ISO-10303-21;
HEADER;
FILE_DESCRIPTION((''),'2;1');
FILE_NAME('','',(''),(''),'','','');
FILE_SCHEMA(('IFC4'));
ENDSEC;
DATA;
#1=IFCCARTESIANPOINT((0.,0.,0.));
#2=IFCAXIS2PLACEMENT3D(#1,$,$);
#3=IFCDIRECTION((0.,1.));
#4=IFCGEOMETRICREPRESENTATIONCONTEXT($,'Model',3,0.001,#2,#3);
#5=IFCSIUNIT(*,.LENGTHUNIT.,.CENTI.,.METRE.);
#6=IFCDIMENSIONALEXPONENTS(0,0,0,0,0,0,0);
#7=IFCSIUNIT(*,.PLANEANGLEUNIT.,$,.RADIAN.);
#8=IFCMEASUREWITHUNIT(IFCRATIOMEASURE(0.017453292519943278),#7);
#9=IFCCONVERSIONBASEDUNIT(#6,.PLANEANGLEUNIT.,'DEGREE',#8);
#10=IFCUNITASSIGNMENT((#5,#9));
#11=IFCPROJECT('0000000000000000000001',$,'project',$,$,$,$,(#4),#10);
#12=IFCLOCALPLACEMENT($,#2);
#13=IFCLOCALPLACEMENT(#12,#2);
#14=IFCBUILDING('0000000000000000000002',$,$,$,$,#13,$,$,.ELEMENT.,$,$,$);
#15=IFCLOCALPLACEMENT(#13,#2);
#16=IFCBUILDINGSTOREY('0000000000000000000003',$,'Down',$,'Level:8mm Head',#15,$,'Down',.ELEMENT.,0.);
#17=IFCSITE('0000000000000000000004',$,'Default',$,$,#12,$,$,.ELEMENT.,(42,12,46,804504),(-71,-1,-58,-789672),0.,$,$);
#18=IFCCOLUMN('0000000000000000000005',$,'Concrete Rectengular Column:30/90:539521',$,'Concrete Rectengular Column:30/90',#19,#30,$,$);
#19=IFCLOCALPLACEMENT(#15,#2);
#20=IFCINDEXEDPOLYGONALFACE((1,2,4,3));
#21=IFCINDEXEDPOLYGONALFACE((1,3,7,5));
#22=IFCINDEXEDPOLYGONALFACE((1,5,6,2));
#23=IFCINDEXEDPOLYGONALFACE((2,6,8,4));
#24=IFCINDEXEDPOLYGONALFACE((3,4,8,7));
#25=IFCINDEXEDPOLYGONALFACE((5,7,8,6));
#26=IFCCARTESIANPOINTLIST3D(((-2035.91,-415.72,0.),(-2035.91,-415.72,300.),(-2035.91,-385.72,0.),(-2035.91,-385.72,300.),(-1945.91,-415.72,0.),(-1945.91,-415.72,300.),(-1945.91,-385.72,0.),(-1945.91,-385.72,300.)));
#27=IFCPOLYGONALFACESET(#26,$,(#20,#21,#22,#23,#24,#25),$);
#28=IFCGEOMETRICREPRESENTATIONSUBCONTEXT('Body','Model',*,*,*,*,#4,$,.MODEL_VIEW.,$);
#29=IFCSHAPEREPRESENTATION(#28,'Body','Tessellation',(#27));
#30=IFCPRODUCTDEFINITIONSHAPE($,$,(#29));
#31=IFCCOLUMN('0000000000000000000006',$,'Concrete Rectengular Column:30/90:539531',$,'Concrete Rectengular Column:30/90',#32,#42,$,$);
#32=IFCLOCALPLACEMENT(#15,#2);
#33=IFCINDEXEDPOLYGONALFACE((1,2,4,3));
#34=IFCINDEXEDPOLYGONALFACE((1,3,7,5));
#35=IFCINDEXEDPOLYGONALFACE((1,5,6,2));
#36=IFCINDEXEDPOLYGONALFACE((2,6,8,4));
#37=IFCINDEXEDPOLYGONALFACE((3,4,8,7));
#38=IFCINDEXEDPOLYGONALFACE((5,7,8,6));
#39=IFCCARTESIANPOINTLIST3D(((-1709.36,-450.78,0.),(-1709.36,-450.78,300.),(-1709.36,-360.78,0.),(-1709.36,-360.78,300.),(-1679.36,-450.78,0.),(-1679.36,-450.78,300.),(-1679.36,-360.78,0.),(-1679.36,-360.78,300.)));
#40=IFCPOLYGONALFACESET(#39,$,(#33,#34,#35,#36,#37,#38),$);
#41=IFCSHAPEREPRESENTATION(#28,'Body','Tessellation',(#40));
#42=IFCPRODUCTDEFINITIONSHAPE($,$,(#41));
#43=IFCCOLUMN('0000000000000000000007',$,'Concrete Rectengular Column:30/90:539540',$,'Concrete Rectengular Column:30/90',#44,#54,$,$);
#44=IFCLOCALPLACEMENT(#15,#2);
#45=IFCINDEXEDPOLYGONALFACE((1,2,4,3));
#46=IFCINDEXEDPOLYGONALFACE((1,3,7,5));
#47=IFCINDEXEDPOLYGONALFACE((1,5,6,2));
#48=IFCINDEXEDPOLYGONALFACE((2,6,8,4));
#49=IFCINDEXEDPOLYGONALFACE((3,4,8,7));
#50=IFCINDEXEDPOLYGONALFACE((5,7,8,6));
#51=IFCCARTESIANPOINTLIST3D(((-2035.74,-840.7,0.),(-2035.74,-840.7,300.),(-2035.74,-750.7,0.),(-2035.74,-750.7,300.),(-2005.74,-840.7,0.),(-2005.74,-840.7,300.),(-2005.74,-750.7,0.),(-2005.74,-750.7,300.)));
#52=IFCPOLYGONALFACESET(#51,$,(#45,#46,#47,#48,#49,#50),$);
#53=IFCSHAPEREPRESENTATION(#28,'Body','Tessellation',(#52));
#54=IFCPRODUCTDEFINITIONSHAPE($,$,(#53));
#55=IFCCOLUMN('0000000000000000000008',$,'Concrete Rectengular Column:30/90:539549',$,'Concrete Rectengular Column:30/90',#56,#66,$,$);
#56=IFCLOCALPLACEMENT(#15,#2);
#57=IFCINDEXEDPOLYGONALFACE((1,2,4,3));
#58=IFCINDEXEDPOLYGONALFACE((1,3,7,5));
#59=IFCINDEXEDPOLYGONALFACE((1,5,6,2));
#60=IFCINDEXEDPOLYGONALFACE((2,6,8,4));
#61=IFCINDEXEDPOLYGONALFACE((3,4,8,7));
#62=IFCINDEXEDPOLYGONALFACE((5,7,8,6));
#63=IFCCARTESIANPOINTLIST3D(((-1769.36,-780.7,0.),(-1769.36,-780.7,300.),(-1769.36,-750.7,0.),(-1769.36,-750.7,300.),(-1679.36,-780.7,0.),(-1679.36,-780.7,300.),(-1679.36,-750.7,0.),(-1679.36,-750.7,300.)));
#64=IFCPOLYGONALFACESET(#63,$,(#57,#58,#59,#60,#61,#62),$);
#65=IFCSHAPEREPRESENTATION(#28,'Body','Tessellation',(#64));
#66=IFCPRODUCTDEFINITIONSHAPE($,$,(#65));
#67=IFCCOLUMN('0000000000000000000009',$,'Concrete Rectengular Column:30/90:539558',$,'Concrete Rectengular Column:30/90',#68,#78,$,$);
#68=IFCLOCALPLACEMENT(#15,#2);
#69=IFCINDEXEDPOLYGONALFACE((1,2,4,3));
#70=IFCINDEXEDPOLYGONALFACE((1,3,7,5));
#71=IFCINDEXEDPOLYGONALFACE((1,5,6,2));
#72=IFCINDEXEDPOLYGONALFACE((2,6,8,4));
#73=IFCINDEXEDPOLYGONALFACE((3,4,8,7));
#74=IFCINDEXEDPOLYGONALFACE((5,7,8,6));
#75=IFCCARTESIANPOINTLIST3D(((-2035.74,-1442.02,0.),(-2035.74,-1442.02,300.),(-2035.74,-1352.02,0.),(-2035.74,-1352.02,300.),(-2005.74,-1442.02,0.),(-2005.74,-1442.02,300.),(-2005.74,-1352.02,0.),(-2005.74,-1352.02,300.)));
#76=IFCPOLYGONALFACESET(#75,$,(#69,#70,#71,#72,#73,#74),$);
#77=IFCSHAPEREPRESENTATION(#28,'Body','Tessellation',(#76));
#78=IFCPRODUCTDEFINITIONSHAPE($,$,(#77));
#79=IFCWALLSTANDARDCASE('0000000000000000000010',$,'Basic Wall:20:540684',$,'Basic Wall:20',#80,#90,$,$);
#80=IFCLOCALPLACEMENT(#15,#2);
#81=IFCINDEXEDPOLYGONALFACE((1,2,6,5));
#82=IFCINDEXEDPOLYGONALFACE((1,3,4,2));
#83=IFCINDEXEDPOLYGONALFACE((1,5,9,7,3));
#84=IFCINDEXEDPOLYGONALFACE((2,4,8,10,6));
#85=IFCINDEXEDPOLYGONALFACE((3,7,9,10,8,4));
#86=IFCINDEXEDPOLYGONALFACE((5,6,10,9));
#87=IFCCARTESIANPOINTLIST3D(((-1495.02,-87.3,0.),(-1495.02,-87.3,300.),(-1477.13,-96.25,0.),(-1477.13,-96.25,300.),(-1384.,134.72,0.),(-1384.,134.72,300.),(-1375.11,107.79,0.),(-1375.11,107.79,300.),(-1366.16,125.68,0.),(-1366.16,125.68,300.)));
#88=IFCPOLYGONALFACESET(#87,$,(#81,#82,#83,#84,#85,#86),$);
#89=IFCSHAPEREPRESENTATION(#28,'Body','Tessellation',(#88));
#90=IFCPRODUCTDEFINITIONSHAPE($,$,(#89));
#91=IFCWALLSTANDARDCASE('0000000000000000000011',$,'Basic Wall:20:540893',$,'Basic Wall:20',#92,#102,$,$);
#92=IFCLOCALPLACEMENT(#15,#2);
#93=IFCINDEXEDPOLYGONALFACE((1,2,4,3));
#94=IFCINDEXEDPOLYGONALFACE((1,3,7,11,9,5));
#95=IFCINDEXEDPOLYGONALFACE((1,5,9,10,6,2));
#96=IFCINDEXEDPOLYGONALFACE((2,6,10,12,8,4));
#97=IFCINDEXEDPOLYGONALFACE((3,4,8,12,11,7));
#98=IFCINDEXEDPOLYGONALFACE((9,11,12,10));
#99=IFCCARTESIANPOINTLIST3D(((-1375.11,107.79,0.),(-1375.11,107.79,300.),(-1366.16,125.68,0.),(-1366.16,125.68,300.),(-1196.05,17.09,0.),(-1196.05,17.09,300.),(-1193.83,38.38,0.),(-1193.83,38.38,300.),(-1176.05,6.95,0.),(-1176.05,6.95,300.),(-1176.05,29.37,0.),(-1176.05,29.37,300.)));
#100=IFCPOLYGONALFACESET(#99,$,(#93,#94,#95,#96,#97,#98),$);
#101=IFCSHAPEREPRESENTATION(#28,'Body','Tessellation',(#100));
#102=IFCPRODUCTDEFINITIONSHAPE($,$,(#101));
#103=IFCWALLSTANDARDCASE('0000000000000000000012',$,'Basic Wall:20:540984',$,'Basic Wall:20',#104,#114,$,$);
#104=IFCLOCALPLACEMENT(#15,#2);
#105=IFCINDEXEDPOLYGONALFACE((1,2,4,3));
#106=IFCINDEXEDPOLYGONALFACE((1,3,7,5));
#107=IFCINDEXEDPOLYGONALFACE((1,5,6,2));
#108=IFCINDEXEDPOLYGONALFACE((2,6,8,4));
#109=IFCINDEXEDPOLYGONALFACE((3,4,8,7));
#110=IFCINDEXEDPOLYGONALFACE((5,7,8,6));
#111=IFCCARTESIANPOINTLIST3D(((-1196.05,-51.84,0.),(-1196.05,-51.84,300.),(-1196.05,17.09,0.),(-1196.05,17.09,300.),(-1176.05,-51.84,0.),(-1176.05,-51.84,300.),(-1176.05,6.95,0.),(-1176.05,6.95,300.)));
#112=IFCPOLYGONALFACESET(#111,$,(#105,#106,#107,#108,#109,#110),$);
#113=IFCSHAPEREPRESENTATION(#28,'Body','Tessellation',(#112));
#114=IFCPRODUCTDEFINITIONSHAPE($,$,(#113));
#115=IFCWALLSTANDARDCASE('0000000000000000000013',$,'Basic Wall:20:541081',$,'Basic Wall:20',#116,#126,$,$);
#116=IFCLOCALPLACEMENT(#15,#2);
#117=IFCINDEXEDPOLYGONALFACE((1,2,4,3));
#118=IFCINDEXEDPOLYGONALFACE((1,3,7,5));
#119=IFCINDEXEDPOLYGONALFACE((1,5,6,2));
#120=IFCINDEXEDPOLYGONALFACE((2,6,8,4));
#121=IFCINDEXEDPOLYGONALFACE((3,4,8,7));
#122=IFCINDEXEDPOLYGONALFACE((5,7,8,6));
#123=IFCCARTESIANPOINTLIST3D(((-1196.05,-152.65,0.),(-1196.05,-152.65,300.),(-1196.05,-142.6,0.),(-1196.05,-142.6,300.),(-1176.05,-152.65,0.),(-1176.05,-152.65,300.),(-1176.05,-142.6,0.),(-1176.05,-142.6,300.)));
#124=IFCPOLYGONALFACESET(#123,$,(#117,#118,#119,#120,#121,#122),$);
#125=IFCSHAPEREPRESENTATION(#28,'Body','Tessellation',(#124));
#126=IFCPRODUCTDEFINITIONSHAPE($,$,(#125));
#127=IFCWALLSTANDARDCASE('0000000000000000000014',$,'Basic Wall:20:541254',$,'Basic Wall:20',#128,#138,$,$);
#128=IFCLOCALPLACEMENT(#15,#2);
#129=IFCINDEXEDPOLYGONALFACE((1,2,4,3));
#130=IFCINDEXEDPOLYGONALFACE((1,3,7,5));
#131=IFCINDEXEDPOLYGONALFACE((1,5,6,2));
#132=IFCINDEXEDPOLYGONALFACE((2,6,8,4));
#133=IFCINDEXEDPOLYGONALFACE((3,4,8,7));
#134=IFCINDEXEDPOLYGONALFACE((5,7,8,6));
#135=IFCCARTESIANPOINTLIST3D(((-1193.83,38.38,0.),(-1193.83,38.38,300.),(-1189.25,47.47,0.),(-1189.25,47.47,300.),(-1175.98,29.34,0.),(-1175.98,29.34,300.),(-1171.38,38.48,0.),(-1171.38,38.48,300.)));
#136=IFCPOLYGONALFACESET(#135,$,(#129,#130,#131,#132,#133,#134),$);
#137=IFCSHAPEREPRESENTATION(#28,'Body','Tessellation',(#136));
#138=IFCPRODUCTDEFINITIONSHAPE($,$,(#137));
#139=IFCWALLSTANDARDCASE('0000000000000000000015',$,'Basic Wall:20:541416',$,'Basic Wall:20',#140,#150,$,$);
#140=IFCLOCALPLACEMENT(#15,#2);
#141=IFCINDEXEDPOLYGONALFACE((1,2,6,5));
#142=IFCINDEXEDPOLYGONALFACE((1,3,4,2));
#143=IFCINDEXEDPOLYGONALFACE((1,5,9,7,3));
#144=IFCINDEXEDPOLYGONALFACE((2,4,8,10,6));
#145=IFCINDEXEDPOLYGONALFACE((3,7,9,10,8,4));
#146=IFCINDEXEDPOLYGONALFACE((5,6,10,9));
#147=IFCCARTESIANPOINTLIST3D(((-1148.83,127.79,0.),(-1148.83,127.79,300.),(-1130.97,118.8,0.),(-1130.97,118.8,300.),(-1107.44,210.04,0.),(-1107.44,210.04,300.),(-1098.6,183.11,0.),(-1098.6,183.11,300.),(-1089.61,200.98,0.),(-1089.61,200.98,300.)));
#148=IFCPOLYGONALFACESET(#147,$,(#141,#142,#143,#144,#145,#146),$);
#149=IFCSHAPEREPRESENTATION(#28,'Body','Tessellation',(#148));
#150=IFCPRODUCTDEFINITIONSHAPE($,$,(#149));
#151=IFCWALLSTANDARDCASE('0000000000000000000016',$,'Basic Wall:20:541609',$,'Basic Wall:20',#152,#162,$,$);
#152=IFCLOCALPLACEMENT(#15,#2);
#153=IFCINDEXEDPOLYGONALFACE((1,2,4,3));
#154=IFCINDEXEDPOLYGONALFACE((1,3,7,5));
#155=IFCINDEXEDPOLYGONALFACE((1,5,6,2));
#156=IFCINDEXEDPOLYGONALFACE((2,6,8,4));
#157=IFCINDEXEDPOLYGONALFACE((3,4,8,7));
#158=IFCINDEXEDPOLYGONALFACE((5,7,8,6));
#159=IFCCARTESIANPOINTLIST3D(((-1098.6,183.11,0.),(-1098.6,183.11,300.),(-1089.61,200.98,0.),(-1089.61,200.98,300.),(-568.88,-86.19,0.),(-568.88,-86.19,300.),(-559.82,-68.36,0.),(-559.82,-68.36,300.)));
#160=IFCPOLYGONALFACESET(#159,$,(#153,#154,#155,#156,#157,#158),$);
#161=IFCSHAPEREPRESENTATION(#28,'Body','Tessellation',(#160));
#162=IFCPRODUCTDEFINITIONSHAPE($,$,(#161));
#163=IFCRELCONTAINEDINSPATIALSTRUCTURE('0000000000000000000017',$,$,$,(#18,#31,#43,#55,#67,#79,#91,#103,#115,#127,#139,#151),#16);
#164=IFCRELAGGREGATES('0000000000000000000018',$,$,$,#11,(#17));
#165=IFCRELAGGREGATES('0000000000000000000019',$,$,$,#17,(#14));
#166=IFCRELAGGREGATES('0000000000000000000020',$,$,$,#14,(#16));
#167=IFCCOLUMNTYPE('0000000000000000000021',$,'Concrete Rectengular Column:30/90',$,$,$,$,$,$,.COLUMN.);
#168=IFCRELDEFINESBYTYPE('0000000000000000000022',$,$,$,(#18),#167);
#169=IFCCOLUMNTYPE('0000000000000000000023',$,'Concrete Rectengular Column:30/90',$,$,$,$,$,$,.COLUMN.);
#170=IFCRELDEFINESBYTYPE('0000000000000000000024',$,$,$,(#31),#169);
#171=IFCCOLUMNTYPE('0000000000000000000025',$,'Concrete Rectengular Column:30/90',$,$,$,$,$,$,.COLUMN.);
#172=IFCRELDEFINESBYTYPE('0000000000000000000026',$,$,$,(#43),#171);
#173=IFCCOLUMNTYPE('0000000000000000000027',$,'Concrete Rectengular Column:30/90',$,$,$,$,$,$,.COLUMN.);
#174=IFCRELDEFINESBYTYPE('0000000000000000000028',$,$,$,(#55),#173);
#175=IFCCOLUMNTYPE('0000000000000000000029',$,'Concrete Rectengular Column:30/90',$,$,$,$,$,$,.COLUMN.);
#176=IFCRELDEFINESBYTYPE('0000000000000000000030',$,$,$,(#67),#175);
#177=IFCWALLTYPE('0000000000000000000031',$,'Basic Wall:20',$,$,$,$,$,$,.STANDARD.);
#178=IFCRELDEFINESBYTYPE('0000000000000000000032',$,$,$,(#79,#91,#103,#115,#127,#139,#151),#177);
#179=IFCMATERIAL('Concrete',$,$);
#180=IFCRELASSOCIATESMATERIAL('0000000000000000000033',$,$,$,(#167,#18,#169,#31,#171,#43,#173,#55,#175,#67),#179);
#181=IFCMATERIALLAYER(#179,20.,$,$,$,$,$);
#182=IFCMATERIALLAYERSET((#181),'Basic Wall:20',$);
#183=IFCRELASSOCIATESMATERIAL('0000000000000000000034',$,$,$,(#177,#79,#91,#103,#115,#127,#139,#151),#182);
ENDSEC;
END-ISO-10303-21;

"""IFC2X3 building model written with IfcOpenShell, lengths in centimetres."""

from ifc_helpers import new_model, entity, si_unit, converted_unit, direction, frame, frame_2d, origin, origin_2d_with_axis, place, context, subcontext, project, spatial, polyline, rectangle, outline, extrude, source, transform, mapped, material, layer, layer_set, layer_usage, type_object, type_shapes, element, save


model = new_model("IFC2X3")

# Units and contexts
model_context = context("Model", 3, precision=0.001, world=origin(), true_north=direction((0.0, 1.0)))
body_context = subcontext(model_context, "Body", "Model", "MODEL_VIEW")
ifc_project = project(units=[si_unit("LENGTHUNIT", "METRE", prefix="CENTI"), converted_unit("PLANEANGLEUNIT", "DEGREE", entity("IfcRatioMeasure", 0.017453292519943278), si_unit("PLANEANGLEUNIT", "RADIAN"), dimensions=[0, 0, 0, 0, 0, 0, 0])], contexts=[model_context])

# Site, building, storey
site_placement = place(None, origin())
site = spatial("IfcSite", under=ifc_project, at=site_placement, Name="Default", CompositionType="ELEMENT", RefLatitude=(42, 12, 46, 804504), RefLongitude=(-71, -1, -58, -789672), RefElevation=0.0)
building_placement = place(site_placement, origin())
building = spatial("IfcBuilding", under=site, at=building_placement, CompositionType="ELEMENT")
storey_placement = place(building_placement, origin())
storey = spatial("IfcBuildingStorey", under=building, at=storey_placement, Name="Down", ObjectType="Level:8mm Head", LongName="Down", CompositionType="ELEMENT", Elevation=0.0)

# Columns
ifc_material = material(Name="Concrete")
column_type_1 = type_object("IfcColumnType", Name="Concrete Rectengular Column:30/90", PredefinedType="COLUMN", material=ifc_material)
shared_shape_1 = source(origin(), body_context, "Body", "SweptSolid", [
    extrude(rectangle(XDim=30.0, YDim=90.0, at=frame_2d((0.0, 0.0), x_axis=(1.0, 0.0))), frame((-1990.91, -400.72, 0.0), z_axis=(0.0, 0.0, 1.0), x_axis=(0.0, -1.0, 0.0)), (0.0, 0.0, 1.0), 300.0),
])
type_shapes(column_type_1, [shared_shape_1])
column_1_placement = place(storey_placement, origin())
element("IfcColumn", 1, at=column_1_placement, inside=storey, type_object=column_type_1, material=ifc_material, Name="Concrete Rectengular Column:30/90:539521", ObjectType="Concrete Rectengular Column:30/90", context=body_context, shape_type="MappedRepresentation", body=[
    mapped(shared_shape_1, transform((0.0, 0.0, 0.0), scale=1.0)),
])
column_type_2 = type_object("IfcColumnType", Name="Concrete Rectengular Column:30/90", PredefinedType="COLUMN", material=ifc_material)
shared_shape_2 = source(origin(), body_context, "Body", "SweptSolid", [
    extrude(rectangle(XDim=90.0, YDim=30.0, at=origin_2d_with_axis()), frame((-1694.36, -405.78, 0.0), z_axis=(0.0, 0.0, 1.0), x_axis=(0.0, -1.0, 0.0)), (0.0, 0.0, 1.0), 300.0),
])
type_shapes(column_type_2, [shared_shape_2])
column_2_placement = place(storey_placement, origin())
element("IfcColumn", 2, at=column_2_placement, inside=storey, type_object=column_type_2, material=ifc_material, Name="Concrete Rectengular Column:30/90:539531", ObjectType="Concrete Rectengular Column:30/90", context=body_context, shape_type="MappedRepresentation", body=[
    mapped(shared_shape_2, transform((0.0, 0.0, 0.0), scale=1.0)),
])
column_type_3 = type_object("IfcColumnType", Name="Concrete Rectengular Column:30/90", PredefinedType="COLUMN", material=ifc_material)
shared_shape_3 = source(origin(), body_context, "Body", "SweptSolid", [
    extrude(rectangle(XDim=90.0, YDim=30.0, at=origin_2d_with_axis()), frame((-2020.74, -795.7, 0.0), z_axis=(0.0, 0.0, 1.0), x_axis=(0.0, -1.0, 0.0)), (0.0, 0.0, 1.0), 300.0),
])
type_shapes(column_type_3, [shared_shape_3])
column_3_placement = place(storey_placement, origin())
element("IfcColumn", 3, at=column_3_placement, inside=storey, type_object=column_type_3, material=ifc_material, Name="Concrete Rectengular Column:30/90:539540", ObjectType="Concrete Rectengular Column:30/90", context=body_context, shape_type="MappedRepresentation", body=[
    mapped(shared_shape_3, transform((0.0, 0.0, 0.0), scale=1.0)),
])
column_type_4 = type_object("IfcColumnType", Name="Concrete Rectengular Column:30/90", PredefinedType="COLUMN", material=ifc_material)
shared_shape_4 = source(origin(), body_context, "Body", "SweptSolid", [
    extrude(rectangle(XDim=30.0, YDim=90.0, at=frame_2d((0.0, 0.0), x_axis=(1.0, 0.0))), frame((-1724.36, -765.7, 0.0), z_axis=(0.0, 0.0, 1.0), x_axis=(0.0, -1.0, 0.0)), (0.0, 0.0, 1.0), 300.0),
])
type_shapes(column_type_4, [shared_shape_4])
column_4_placement = place(storey_placement, origin())
element("IfcColumn", 4, at=column_4_placement, inside=storey, type_object=column_type_4, material=ifc_material, Name="Concrete Rectengular Column:30/90:539549", ObjectType="Concrete Rectengular Column:30/90", context=body_context, shape_type="MappedRepresentation", body=[
    mapped(shared_shape_4, transform((0.0, 0.0, 0.0), scale=1.0)),
])
column_type_5 = type_object("IfcColumnType", Name="Concrete Rectengular Column:30/90", PredefinedType="COLUMN", material=ifc_material)
shared_shape_5 = source(origin(), body_context, "Body", "SweptSolid", [
    extrude(rectangle(XDim=90.0, YDim=30.0, at=frame_2d((0.0, 0.0), x_axis=(1.0, 0.0))), frame((-2020.74, -1397.02, 0.0), z_axis=(0.0, 0.0, 1.0), x_axis=(0.0, -1.0, 0.0)), (0.0, 0.0, 1.0), 300.0),
])
type_shapes(column_type_5, [shared_shape_5])
column_5_placement = place(storey_placement, origin())
element("IfcColumn", 5, at=column_5_placement, inside=storey, type_object=column_type_5, material=ifc_material, Name="Concrete Rectengular Column:30/90:539558", ObjectType="Concrete Rectengular Column:30/90", context=body_context, shape_type="MappedRepresentation", body=[
    mapped(shared_shape_5, transform((0.0, 0.0, 0.0), scale=1.0)),
])

# Walls
ifc_layer_1 = layer(ifc_material, 20.0)
ifc_layer_set_1 = layer_set([ifc_layer_1], Name="Basic Wall:20")
ifc_layer_usage_1 = layer_usage(ifc_layer_set_1, "AXIS2", "NEGATIVE", 10.0)
wall_type_1 = type_object("IfcWallType", Name="Basic Wall:20", PredefinedType="STANDARD", material=ifc_layer_set_1)
wall_1_placement = place(storey_placement, frame((-1486.07, -91.78, 0.0), z_axis=(0.0, 0.0, 1.0), x_axis=(0.447214, 0.894427, 0.0)))
element("IfcWallStandardCase", 6, at=wall_1_placement, inside=storey, type_object=wall_type_1, material=ifc_layer_usage_1, Name="Basic Wall:20:540684", ObjectType="Basic Wall:20", context=body_context, shape_type="SweptSolid", body=[
    extrude(outline(polyline([(248.12, -10.0), (248.23, 10.0), (0.0, 10.0), (0.0, -10.0), (228.12, -10.0), (248.12, -10.0)])), origin(), (0.0, 0.0, 1.0), 300.0),
])
ifc_layer_usage_2 = layer_usage(ifc_layer_set_1, "AXIS2", "NEGATIVE", 10.0)
wall_2_placement = place(storey_placement, frame((-1370.68, 116.76, 0.0), z_axis=(0.0, 0.0, 1.0), x_axis=(0.892067, -0.451903, 0.0)))
element("IfcWallStandardCase", 7, at=wall_2_placement, inside=storey, type_object=wall_type_1, material=ifc_layer_usage_2, Name="Basic Wall:20:540893", ObjectType="Basic Wall:20", context=body_context, shape_type="SweptSolid", body=[
    extrude(outline(polyline([(223.24, -10.0), (213.11, 10.0), (193.19, 10.0), (0.0, 10.0), (0.1, -10.0), (200.82, -10.0), (223.24, -10.0)])), origin(), (0.0, 0.0, 1.0), 300.0),
])
ifc_layer_usage_3 = layer_usage(ifc_layer_set_1, "AXIS2", "NEGATIVE", 10.0)
wall_3_placement = place(storey_placement, frame((-1186.05, 17.09, 0.0), z_axis=(0.0, 0.0, 1.0), x_axis=(0.0, -1.0, 0.0)))
element("IfcWallStandardCase", 8, at=wall_3_placement, inside=storey, type_object=wall_type_1, material=ifc_layer_usage_3, Name="Basic Wall:20:540984", ObjectType="Basic Wall:20", context=body_context, shape_type="SweptSolid", body=[
    extrude(outline(polyline([(68.92, -10.0), (68.92, 10.0), (10.13, 10.0), (0.0, -10.0), (68.92, -10.0)])), origin(), (0.0, 0.0, 1.0), 300.0),
])
ifc_layer_usage_4 = layer_usage(ifc_layer_set_1, "AXIS2", "POSITIVE", -10.0)
wall_4_placement = place(storey_placement, frame((-1186.05, -142.6, 0.0), z_axis=(0.0, 0.0, 1.0), x_axis=(0.0, -1.0, 0.0)))
element("IfcWallStandardCase", 9, at=wall_4_placement, inside=storey, type_object=wall_type_1, material=ifc_layer_usage_4, Name="Basic Wall:20:541081", ObjectType="Basic Wall:20", context=body_context, shape_type="SweptSolid", body=[
    extrude(rectangle(XDim=10.05, YDim=20.0, at=frame_2d((5.03, 0.0), x_axis=(-1.0, 0.0))), origin(), (0.0, 0.0, 1.0), 300.0),
])
ifc_layer_usage_5 = layer_usage(ifc_layer_set_1, "AXIS2", "POSITIVE", -10.0)
wall_5_placement = place(storey_placement, frame((-1184.92, 33.84, 0.0), z_axis=(0.0, 0.0, 1.0), x_axis=(0.449517, 0.893272, 0.0)))
element("IfcWallStandardCase", 10, at=wall_5_placement, inside=storey, type_object=wall_type_1, material=ifc_layer_usage_5, Name="Basic Wall:20:541254", ObjectType="Basic Wall:20", context=body_context, shape_type="SweptSolid", body=[
    extrude(outline(polyline([(10.23, -10.0), (10.23, 10.0), (0.05, 10.0), (0.0, -10.0), (10.23, -10.0)])), origin(), (0.0, 0.0, 1.0), 300.0),
])
ifc_layer_usage_6 = layer_usage(ifc_layer_set_1, "AXIS2", "POSITIVE", -10.0)
wall_6_placement = place(storey_placement, frame((-1139.9, 123.29, 0.0), z_axis=(0.0, 0.0, 1.0), x_axis=(0.449517, 0.893272, 0.0)))
element("IfcWallStandardCase", 11, at=wall_6_placement, inside=storey, type_object=wall_type_1, material=ifc_layer_usage_6, Name="Basic Wall:20:541416", ObjectType="Basic Wall:20", context=body_context, shape_type="SweptSolid", body=[
    extrude(outline(polyline([(92.0, -10.0), (92.08, 10.0), (0.0, 10.0), (0.0, -10.0), (72.0, -10.0), (92.0, -10.0)])), origin(), (0.0, 0.0, 1.0), 300.0),
])
ifc_layer_usage_7 = layer_usage(ifc_layer_set_1, "AXIS2", "NEGATIVE", 10.0)
wall_7_placement = place(storey_placement, frame((-1094.14, 192.06, 0.0), z_axis=(0.0, 0.0, 1.0), x_axis=(0.891419, -0.45318, 0.0)))
element("IfcWallStandardCase", 12, at=wall_7_placement, inside=storey, type_object=wall_type_1, material=ifc_layer_usage_7, Name="Basic Wall:20:541609", ObjectType="Basic Wall:20", context=body_context, shape_type="SweptSolid", body=[
    extrude(outline(polyline([(594.33, -10.0), (594.33, 10.0), (0.0, 10.0), (0.08, -10.0), (594.33, -10.0)])), origin(), (0.0, 0.0, 1.0), 300.0),
])

save(model, "model.ifc")
